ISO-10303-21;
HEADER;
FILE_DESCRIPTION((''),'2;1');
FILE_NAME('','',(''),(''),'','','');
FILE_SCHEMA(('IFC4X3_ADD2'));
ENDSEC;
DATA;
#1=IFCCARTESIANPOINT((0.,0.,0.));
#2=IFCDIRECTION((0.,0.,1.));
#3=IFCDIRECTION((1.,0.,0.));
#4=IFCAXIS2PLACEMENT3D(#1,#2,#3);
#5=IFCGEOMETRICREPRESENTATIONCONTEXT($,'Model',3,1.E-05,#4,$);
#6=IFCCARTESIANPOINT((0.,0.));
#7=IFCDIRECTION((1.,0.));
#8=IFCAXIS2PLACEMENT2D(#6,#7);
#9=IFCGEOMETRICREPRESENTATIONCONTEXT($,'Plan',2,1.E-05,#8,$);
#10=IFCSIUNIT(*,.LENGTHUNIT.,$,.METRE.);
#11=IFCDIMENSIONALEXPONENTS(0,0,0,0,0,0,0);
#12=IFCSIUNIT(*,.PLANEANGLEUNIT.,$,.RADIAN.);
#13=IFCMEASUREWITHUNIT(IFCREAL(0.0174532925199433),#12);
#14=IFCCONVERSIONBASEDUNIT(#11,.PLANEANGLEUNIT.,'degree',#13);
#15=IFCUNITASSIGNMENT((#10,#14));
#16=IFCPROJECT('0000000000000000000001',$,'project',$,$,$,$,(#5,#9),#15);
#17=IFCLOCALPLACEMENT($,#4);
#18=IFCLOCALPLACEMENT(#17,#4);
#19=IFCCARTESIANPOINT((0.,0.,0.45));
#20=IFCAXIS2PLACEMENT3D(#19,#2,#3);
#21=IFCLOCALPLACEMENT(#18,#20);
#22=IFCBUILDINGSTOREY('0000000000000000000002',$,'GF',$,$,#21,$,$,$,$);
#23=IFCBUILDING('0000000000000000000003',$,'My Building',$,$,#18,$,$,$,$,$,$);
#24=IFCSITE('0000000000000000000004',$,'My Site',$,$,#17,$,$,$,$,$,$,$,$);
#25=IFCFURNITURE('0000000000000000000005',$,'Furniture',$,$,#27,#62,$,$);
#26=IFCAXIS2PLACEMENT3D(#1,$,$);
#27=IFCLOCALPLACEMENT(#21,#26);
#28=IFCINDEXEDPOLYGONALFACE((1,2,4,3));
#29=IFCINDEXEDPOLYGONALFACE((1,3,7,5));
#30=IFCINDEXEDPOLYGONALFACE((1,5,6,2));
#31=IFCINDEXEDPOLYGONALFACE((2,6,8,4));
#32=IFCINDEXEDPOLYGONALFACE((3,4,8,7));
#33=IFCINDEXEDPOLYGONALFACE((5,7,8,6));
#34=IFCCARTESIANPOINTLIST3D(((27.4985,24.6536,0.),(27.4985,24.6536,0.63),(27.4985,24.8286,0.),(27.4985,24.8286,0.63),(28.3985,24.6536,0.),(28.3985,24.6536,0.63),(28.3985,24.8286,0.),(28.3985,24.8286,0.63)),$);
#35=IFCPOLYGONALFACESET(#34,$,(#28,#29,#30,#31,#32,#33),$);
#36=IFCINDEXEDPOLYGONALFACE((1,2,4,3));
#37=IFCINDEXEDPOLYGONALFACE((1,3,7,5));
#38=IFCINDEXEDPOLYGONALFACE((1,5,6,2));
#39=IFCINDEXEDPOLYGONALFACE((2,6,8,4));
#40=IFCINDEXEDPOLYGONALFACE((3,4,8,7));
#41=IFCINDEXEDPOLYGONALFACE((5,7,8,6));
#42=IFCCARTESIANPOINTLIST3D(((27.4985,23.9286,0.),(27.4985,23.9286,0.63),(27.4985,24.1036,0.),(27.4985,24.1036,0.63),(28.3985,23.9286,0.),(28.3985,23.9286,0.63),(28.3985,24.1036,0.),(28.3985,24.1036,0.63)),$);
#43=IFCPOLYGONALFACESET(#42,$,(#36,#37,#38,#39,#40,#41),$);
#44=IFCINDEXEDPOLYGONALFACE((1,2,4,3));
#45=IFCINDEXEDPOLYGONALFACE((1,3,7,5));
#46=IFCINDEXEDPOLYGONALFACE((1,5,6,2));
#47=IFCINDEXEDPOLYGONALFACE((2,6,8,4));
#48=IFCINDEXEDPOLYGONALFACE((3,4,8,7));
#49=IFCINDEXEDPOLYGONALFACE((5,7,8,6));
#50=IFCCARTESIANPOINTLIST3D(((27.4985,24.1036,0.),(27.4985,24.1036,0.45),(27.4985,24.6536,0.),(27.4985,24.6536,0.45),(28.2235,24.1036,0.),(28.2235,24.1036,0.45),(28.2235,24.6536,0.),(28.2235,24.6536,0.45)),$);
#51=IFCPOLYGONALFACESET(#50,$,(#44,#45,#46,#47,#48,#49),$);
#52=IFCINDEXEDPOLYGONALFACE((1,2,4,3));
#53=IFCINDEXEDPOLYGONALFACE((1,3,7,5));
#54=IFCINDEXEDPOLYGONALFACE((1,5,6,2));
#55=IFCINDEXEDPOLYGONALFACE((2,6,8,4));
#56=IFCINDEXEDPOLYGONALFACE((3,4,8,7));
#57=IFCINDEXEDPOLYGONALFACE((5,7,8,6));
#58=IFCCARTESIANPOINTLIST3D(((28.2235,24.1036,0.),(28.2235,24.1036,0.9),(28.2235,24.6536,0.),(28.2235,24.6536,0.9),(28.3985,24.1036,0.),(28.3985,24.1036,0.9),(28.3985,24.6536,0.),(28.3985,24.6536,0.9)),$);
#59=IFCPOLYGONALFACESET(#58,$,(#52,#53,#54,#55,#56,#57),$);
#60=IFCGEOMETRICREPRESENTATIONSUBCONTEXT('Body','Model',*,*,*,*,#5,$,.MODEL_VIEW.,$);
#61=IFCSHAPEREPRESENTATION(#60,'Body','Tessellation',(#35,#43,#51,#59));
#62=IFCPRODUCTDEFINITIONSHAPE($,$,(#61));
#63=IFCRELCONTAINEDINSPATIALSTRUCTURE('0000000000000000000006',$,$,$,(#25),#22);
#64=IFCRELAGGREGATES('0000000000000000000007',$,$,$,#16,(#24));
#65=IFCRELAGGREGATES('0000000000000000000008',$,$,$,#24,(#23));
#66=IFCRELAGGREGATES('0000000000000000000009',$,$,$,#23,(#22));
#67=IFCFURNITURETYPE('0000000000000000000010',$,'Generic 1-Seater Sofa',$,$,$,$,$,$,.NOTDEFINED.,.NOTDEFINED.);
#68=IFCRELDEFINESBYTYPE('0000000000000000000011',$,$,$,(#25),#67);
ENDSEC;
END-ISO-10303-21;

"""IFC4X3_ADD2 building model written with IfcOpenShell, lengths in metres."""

from ifc_helpers import new_model, entity, si_unit, converted_unit, frame, origin_with_axes, origin_2d_with_axis, place, context, subcontext, project, spatial, line, indexed_curve, outline, extrude, shape, source, transform, mapped, type_object, type_shapes, element, save


model = new_model("IFC4X3_ADD2")

# Units and contexts
model_context = context("Model", 3, precision=1e-05, world=origin_with_axes())
plan_context = context("Plan", 2, precision=1e-05, world=origin_2d_with_axis())
body_context_1 = subcontext(model_context, "Body", "Model", "MODEL_VIEW")
body_context_2 = subcontext(plan_context, "Body", "Plan", "PLAN_VIEW")
ifc_project = project(units=[si_unit("LENGTHUNIT", "METRE"), converted_unit("PLANEANGLEUNIT", "degree", entity("IfcReal", 0.0174532925199433), si_unit("PLANEANGLEUNIT", "RADIAN"), dimensions=[0, 0, 0, 0, 0, 0, 0])], contexts=[model_context, plan_context])

# Site, building, storey
site_placement = place(None, origin_with_axes())
site = spatial("IfcSite", under=ifc_project, at=site_placement, Name="My Site")
building_placement = place(site_placement, origin_with_axes())
building = spatial("IfcBuilding", under=site, at=building_placement, Name="My Building")
storey_placement = place(building_placement, frame((0.0, 0.0, 0.45), z_axis=(0.0, 0.0, 1.0), x_axis=(1.0, 0.0, 0.0)))
storey = spatial("IfcBuildingStorey", under=building, at=storey_placement, Name="GF")

# Furniture
furniture_type_1 = type_object("IfcFurnitureType", Name="Generic 1-Seater Sofa", AssemblyPlace="NOTDEFINED", PredefinedType="NOTDEFINED")
shared_shape_1 = source(origin_with_axes(), body_context_1, "Body", "SweptSolid", [
    extrude(outline(indexed_curve([(0.0, 0.0), (0.175, 0.0), (0.175, 0.9), (0.0, 0.9)], segments=[line(1, 2, 3, 4, 1)])), frame((-0.45, -0.9, 0.0), z_axis=(0.0, 0.0, 1.0), x_axis=(1.0, 0.0, 0.0)), (0.0, 0.0, 1.0), 0.63),
    extrude(outline(indexed_curve([(0.0, 0.0), (0.175, 0.0), (0.175, 0.9), (0.0, 0.9)], segments=[line(1, 2, 3, 4, 1)])), frame((0.275, -0.9, 0.0), z_axis=(0.0, 0.0, 1.0), x_axis=(1.0, 0.0, 0.0)), (0.0, 0.0, 1.0), 0.63),
    extrude(outline(indexed_curve([(0.175, 0.0), (0.725, 0.0), (0.725, 0.725), (0.175, 0.725)], segments=[line(1, 2, 3, 4, 1)])), frame((-0.45, -0.9, 0.0), z_axis=(0.0, 0.0, 1.0), x_axis=(1.0, 0.0, 0.0)), (0.0, 0.0, 1.0), 0.45),
    extrude(outline(indexed_curve([(0.175, 0.725), (0.725, 0.725), (0.725, 0.9), (0.175, 0.9)], segments=[line(1, 2, 3, 4, 1)])), frame((-0.45, -0.9, 0.0), z_axis=(0.0, 0.0, 1.0), x_axis=(1.0, 0.0, 0.0)), (0.0, 0.0, 1.0), 0.9),
])
shared_shape_2 = source(origin_with_axes(), body_context_2, "Body", "Annotation2D", [
    entity("IfcGeometricCurveSet", [entity("IfcIndexedPolyCurve", entity("IfcCartesianPointList2D", [[0.275, -0.175], [0.275, -0.9], [0.45, -0.9], [0.45, 0.0], [0.275, 0.0], [0.275, -0.9], [-0.275, -0.9], [-0.275, 0.0], [-0.275, -0.175], [0.275, -0.175], [0.275, 0.0], [-0.275, 0.0], [-0.45, 0.0], [-0.45, -0.9], [-0.275, -0.9], [-0.275, -0.175]]))]),
])
type_shapes(furniture_type_1, [shared_shape_1, shared_shape_2])
for number, where, z_axis, x_axis, name in (
    (1, (28.3985, 24.3786, 0.0), (0.0, 0.0, 1.0), (0.0, -1.0, 0.0), "Furniture"),
):
    element("IfcFurniture", number, at=place(storey_placement, frame(where, z_axis=z_axis, x_axis=x_axis)), inside=storey, type_object=furniture_type_1, Name=name, shapes=[
        shape(body_context_1, "Body", "MappedRepresentation", [mapped(shared_shape_1, transform((0.0, 0.0, 0.0), x_axis=(1.0, 0.0, 0.0), y_axis=(0.0, 1.0, 0.0), z_axis=(0.0, 0.0, 1.0), scale=1.0))]),
        shape(body_context_2, "Body", "MappedRepresentation", [mapped(shared_shape_2, transform((0.0, 0.0, 0.0), x_axis=(1.0, 0.0, 0.0), y_axis=(0.0, 1.0, 0.0), z_axis=(0.0, 0.0, 1.0), scale=1.0))]),
    ])

save(model, "model.ifc")
